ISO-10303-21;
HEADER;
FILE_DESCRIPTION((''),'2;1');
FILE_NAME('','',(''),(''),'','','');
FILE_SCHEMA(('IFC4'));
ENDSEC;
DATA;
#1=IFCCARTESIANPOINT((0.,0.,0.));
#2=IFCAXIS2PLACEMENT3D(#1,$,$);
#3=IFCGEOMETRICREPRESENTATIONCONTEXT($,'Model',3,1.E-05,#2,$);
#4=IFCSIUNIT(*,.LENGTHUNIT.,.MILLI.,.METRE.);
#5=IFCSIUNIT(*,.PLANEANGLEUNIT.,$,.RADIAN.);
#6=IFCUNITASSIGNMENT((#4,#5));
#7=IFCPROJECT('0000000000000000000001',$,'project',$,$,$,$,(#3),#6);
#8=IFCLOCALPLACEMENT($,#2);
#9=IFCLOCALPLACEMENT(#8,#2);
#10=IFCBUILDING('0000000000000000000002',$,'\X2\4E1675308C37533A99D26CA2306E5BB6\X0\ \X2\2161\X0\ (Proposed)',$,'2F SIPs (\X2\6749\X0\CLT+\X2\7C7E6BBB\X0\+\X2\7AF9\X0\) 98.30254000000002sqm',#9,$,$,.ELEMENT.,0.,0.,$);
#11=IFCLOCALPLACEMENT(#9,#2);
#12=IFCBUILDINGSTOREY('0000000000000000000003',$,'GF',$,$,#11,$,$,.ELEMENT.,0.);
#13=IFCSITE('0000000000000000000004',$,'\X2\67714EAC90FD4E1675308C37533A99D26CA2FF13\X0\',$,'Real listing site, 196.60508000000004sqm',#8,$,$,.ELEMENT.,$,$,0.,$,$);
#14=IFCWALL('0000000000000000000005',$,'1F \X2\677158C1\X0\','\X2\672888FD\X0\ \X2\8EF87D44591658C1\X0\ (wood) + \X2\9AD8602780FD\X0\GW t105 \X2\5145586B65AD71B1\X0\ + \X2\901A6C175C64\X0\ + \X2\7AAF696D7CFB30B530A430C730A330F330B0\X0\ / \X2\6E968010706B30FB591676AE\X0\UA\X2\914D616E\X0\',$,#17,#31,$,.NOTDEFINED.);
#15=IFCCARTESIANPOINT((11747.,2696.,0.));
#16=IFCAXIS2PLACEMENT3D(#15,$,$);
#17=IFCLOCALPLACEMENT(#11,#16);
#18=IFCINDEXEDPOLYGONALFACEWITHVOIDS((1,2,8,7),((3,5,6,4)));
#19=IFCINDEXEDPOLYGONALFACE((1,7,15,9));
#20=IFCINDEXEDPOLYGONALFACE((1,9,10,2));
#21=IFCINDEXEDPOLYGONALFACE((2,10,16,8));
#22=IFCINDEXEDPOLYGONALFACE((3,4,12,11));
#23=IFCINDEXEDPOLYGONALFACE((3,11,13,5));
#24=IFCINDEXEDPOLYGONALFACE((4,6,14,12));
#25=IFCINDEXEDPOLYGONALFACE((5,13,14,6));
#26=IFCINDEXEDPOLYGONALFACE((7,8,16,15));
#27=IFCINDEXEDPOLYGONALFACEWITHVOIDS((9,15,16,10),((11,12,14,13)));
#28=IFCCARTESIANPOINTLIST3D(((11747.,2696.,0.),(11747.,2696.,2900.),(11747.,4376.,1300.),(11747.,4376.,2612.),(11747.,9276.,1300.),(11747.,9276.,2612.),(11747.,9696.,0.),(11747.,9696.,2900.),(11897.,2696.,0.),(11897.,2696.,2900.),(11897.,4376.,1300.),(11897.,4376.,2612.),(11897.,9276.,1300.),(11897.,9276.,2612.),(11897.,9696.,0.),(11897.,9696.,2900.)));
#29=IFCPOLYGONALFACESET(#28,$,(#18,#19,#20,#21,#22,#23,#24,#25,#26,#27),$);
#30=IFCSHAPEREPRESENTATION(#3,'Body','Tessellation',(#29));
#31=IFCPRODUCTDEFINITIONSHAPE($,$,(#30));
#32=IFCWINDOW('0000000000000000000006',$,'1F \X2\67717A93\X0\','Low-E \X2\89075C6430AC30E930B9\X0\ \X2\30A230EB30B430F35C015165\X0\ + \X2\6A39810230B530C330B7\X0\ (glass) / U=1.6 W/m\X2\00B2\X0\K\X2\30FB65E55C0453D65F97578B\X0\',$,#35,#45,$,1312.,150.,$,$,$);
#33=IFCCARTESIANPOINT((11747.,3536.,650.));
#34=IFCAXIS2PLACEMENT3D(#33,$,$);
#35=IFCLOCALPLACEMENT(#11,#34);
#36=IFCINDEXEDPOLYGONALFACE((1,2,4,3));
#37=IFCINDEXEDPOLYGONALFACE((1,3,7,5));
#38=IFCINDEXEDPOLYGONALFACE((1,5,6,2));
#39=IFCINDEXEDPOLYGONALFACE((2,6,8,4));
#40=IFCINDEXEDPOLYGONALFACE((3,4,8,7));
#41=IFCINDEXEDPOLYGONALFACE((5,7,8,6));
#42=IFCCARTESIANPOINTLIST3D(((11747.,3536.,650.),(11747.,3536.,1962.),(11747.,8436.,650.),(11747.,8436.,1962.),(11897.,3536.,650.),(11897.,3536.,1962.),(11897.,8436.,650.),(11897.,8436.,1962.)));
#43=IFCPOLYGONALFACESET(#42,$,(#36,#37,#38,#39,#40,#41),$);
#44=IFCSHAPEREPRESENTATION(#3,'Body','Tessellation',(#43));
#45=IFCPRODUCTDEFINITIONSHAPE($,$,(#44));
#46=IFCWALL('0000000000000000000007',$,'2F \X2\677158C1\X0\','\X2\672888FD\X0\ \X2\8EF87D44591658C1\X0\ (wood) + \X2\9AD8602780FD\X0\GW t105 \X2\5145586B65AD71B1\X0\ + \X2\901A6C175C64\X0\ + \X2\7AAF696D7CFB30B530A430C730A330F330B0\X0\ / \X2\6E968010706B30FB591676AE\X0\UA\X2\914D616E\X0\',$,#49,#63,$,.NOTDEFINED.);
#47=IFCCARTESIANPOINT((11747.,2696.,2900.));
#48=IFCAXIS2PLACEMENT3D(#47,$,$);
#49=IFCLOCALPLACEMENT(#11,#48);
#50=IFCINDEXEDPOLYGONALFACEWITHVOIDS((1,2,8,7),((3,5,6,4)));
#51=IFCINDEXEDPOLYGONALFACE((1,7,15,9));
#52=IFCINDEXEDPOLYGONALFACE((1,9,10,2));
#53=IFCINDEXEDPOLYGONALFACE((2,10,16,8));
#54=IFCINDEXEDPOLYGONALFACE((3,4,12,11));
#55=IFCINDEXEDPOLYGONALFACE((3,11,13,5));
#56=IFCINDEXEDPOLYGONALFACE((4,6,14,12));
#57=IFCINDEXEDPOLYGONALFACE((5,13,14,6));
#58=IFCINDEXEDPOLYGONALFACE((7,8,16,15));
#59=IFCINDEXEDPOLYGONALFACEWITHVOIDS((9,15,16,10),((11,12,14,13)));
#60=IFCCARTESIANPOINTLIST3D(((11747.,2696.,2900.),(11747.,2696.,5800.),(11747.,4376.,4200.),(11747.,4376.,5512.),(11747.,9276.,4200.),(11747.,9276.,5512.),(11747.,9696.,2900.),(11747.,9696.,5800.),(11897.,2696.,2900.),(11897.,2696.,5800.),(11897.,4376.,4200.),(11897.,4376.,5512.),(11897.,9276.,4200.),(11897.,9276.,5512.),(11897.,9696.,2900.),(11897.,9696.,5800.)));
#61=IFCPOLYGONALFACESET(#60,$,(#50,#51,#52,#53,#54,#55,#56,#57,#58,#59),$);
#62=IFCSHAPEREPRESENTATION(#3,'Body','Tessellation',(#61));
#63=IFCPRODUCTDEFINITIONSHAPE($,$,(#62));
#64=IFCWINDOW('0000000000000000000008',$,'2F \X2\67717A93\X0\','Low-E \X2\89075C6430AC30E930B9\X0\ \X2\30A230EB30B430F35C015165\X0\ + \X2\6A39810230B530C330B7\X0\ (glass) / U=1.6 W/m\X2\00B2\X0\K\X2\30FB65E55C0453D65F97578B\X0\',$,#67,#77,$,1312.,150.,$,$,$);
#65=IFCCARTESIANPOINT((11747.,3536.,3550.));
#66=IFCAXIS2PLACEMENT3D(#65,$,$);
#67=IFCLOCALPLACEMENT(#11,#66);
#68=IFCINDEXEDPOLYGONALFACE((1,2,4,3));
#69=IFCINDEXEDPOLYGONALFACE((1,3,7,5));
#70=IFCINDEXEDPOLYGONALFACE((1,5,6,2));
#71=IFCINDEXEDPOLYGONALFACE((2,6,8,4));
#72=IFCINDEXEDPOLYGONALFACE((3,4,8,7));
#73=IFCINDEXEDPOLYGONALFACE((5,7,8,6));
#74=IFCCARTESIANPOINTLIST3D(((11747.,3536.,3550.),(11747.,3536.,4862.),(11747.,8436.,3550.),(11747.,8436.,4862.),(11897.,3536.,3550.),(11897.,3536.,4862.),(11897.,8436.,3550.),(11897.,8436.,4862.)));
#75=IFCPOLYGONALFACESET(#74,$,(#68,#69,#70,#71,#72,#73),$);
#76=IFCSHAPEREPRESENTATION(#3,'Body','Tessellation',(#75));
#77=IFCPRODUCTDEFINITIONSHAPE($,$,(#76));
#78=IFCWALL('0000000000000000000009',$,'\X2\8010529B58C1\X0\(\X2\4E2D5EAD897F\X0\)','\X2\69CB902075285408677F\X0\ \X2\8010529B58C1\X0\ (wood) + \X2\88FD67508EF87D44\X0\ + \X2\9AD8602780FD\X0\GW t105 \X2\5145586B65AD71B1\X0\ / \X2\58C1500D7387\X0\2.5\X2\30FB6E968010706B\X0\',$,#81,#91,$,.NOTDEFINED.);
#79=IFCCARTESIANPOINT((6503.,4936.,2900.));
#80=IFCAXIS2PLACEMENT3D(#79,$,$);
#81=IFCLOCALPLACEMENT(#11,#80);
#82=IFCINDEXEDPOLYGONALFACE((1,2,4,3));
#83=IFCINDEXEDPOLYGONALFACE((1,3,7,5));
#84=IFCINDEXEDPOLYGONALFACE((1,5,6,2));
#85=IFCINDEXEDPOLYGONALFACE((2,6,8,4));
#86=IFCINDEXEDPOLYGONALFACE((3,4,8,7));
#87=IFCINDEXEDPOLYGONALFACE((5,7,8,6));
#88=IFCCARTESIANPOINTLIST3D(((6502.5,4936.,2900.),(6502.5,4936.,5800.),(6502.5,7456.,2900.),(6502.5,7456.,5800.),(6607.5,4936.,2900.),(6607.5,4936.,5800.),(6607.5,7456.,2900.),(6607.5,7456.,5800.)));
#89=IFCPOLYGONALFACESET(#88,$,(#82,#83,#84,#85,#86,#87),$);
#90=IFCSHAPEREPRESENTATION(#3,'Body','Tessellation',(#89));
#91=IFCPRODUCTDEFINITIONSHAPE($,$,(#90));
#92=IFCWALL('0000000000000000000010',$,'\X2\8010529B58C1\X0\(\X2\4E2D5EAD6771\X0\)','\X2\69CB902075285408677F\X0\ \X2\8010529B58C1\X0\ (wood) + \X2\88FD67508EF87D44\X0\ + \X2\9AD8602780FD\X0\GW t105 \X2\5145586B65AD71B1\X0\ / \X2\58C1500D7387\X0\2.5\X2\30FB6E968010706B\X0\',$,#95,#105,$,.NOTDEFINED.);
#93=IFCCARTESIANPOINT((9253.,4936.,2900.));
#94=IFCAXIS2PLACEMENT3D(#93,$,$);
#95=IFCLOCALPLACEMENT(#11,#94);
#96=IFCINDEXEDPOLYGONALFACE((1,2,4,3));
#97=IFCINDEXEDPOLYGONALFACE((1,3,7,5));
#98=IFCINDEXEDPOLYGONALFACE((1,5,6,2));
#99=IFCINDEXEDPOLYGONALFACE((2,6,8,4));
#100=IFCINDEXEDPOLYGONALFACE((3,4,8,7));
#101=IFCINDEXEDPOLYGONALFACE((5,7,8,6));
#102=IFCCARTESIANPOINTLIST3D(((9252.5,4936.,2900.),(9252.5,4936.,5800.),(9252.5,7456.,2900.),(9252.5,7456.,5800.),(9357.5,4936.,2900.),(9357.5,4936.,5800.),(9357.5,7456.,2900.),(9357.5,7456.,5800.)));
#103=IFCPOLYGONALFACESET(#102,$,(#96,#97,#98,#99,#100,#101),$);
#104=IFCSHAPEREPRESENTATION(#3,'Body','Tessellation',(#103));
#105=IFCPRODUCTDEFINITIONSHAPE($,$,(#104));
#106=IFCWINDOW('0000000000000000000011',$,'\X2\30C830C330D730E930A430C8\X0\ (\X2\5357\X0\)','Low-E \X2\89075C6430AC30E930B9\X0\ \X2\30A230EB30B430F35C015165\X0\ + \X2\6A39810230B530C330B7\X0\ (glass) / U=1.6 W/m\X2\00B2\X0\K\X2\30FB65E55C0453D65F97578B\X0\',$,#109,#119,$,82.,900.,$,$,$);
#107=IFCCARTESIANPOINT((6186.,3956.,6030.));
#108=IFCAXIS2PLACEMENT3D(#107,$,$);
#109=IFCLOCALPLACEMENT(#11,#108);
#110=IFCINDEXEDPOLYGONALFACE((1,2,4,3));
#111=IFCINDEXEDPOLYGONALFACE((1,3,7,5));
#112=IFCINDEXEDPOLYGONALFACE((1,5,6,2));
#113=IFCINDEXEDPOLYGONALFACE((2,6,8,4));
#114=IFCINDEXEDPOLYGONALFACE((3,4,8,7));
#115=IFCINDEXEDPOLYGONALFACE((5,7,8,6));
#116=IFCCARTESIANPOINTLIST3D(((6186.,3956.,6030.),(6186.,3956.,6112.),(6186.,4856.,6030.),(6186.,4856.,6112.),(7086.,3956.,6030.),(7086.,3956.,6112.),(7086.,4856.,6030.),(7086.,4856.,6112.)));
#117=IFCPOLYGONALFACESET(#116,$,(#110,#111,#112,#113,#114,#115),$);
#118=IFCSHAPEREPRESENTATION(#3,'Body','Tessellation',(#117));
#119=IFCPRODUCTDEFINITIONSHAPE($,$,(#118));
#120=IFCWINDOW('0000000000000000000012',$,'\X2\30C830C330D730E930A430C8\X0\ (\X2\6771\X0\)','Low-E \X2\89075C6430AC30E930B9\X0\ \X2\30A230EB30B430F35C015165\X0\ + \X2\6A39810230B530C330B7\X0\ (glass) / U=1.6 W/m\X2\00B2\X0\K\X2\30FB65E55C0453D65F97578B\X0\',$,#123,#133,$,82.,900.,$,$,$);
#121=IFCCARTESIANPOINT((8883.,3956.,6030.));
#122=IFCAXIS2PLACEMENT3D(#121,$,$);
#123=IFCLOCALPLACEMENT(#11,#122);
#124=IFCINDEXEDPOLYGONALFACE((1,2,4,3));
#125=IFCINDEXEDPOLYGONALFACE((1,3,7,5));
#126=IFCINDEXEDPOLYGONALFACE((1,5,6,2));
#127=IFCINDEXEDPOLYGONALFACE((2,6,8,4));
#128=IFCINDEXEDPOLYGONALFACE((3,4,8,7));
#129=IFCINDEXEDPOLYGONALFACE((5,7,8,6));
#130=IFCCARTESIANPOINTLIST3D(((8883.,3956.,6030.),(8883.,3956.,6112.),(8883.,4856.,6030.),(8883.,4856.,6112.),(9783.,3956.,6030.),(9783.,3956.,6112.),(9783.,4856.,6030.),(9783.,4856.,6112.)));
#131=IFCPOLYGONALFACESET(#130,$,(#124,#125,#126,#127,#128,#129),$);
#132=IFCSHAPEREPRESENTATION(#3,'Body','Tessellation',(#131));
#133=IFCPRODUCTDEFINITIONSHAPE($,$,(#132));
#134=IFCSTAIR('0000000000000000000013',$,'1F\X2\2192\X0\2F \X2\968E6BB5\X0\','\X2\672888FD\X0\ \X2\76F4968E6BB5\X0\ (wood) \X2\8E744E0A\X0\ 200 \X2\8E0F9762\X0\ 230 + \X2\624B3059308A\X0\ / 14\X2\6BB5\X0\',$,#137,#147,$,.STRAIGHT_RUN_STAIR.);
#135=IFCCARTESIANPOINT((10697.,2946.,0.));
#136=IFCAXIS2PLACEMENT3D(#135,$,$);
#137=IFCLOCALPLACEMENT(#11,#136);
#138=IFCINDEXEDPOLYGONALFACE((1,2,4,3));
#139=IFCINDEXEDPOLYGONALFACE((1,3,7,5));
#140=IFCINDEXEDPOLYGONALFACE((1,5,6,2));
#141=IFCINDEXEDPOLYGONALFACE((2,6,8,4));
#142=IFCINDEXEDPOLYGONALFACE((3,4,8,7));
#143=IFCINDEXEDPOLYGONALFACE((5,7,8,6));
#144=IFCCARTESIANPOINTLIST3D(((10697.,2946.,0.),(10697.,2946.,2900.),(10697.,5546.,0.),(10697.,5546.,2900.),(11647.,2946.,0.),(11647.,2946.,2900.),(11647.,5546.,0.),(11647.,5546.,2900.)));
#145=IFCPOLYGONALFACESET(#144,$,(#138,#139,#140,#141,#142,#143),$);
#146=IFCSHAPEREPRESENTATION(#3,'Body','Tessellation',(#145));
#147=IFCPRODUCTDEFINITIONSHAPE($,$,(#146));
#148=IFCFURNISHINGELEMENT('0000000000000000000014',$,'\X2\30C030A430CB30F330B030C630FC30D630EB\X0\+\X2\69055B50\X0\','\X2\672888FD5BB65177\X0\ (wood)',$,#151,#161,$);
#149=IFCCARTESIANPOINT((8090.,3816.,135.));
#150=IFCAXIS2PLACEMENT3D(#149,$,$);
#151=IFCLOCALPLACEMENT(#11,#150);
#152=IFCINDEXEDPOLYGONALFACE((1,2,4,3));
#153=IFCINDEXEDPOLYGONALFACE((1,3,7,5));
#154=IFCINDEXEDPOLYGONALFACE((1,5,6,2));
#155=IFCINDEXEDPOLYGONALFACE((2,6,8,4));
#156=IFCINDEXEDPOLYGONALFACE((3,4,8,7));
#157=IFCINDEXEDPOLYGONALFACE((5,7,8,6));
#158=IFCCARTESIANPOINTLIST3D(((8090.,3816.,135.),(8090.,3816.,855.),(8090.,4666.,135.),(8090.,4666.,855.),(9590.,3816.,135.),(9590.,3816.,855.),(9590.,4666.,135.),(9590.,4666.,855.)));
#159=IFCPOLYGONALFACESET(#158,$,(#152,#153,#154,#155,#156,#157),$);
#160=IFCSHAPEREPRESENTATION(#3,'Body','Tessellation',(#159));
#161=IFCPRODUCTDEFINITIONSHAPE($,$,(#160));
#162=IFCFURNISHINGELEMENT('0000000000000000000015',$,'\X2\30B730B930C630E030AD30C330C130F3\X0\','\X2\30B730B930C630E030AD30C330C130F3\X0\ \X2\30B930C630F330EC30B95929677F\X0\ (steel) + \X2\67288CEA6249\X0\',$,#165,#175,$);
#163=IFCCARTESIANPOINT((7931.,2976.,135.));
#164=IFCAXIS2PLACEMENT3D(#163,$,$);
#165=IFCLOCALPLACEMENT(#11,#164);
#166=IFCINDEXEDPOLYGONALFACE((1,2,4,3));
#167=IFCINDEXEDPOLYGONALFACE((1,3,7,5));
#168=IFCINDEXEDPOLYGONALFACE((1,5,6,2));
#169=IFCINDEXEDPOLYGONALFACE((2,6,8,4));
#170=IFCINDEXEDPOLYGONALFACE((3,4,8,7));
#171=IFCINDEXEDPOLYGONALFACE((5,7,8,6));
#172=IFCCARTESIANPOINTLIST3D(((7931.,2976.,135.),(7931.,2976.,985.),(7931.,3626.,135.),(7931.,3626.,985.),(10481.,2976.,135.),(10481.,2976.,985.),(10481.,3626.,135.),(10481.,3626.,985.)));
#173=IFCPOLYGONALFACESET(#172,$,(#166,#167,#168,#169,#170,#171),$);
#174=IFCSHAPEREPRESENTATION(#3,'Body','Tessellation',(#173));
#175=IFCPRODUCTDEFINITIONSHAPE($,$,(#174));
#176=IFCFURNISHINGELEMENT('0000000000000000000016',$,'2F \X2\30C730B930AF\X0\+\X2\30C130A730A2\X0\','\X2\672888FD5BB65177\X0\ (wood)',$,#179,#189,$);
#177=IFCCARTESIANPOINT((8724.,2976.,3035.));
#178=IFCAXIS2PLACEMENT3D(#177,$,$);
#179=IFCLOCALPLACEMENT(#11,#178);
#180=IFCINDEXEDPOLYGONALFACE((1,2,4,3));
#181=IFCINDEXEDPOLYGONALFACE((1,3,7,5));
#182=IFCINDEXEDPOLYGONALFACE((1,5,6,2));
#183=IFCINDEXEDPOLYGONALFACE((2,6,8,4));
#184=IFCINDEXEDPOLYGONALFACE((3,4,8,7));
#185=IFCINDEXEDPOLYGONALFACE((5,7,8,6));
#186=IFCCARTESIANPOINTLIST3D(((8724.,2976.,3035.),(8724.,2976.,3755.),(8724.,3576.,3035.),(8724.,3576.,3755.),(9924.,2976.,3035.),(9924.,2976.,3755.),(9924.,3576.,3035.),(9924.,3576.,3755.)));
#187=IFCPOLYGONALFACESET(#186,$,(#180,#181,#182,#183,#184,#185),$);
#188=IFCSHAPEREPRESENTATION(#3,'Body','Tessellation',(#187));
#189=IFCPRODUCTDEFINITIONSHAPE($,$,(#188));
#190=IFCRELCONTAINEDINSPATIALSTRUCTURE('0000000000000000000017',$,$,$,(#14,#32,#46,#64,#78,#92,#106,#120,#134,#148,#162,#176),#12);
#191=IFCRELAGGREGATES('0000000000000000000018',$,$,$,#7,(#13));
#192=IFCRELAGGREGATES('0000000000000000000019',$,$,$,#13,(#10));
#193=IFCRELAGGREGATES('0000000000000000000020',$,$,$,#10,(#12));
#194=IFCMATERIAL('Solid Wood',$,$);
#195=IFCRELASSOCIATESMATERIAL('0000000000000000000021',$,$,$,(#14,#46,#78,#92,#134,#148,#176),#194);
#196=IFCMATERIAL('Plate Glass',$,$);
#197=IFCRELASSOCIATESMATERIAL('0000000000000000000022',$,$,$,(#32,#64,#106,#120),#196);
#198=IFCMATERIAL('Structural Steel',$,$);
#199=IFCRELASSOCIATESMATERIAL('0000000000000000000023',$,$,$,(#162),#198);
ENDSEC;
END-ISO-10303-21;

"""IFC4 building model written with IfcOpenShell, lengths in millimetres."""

from ifc_helpers import new_model, si_unit, frame, frame_2d, origin, place, context, project, spatial, rectangle, extrude, material, element, fill, save


model = new_model("IFC4")

# Units and contexts
model_context = context("Model", 3, precision=1e-05, world=origin())
ifc_project = project(units=[si_unit("LENGTHUNIT", "METRE", prefix="MILLI"), si_unit("PLANEANGLEUNIT", "RADIAN")], contexts=[model_context])

# Site, building, storey
site_placement = place(None, origin())
site = spatial("IfcSite", under=ifc_project, at=site_placement, Name="東京都世田谷区駒沢３", ObjectType="Real listing site, 196.60508000000004sqm", CompositionType="ELEMENT", RefElevation=0.0)
building_placement = place(site_placement, origin())
building = spatial("IfcBuilding", under=site, at=building_placement, Name="世田谷区駒沢の家 Ⅱ (Proposed)", ObjectType="2F SIPs (杉CLT+籾殻+竹) 98.30254000000002sqm", CompositionType="ELEMENT", ElevationOfRefHeight=0.0, ElevationOfTerrain=0.0)
storey_placement = place(building_placement, origin())
storey = spatial("IfcBuildingStorey", under=building, at=storey_placement, Name="GF", CompositionType="ELEMENT", Elevation=0.0)

# Shared definitions
ifc_material_1 = material(Name="Solid Wood")

# Wall, opening, window
wall_1_placement = place(storey_placement, frame((11747.0, 2696.0, 0.0)))
wall_1 = element("IfcWall", 1, at=wall_1_placement, inside=storey, material=ifc_material_1, Name="1F 東壁", Description="木製 軸組外壁 (wood) + 高性能GW t105 充填断熱 + 通気層 + 窯業系サイディング / 準耐火・外皮UA配慮", PredefinedType="NOTDEFINED", context=model_context, shape_type="SweptSolid", body=[
    extrude(rectangle(XDim=150.0, YDim=7000.0, at=frame_2d((75.0, 3500.0))), frame((11747.0, 2696.0, 0.0)), (0.0, 0.0, 1.0), 2900.0),
])
opening_1_placement = place(storey_placement, frame((11747.0, 3536.0, 650.0)))
opening_1 = element("IfcOpeningElement", 2, at=opening_1_placement, cuts=wall_1, PredefinedType="NOTDEFINED", context=model_context, shape_type="SweptSolid", body=[
    extrude(rectangle(XDim=150.0, YDim=4900.0, at=frame_2d((75.0, 2450.0))), frame((11747.0, 3536.0, 650.0)), (0.0, 0.0, 1.0), 1312.0),
])
ifc_material_2 = material(Name="Plate Glass")
window_1_placement = place(storey_placement, frame((11747.0, 3536.0, 650.0)))
window_1 = element("IfcWindow", 3, at=window_1_placement, inside=storey, material=ifc_material_2, Name="1F 東窓", Description="Low-E 複層ガラス アルゴン封入 + 樹脂サッシ (glass) / U=1.6 W/m²K・日射取得型", OverallHeight=1312.0, OverallWidth=150.0, context=model_context, shape_type="SweptSolid", body=[
    extrude(rectangle(XDim=150.0, YDim=4900.0, at=frame_2d((75.0, 2450.0))), frame((11747.0, 3536.0, 650.0)), (0.0, 0.0, 1.0), 1312.0),
])
fill(opening_1, window_1)

# Wall, opening, window
wall_2_placement = place(storey_placement, frame((11747.0, 2696.0, 2900.0)))
wall_2 = element("IfcWall", 4, at=wall_2_placement, inside=storey, material=ifc_material_1, Name="2F 東壁", Description="木製 軸組外壁 (wood) + 高性能GW t105 充填断熱 + 通気層 + 窯業系サイディング / 準耐火・外皮UA配慮", PredefinedType="NOTDEFINED", context=model_context, shape_type="SweptSolid", body=[
    extrude(rectangle(XDim=150.0, YDim=7000.0, at=frame_2d((75.0, 3500.0))), frame((11747.0, 2696.0, 2900.0)), (0.0, 0.0, 1.0), 2900.0),
])
opening_2_placement = place(storey_placement, frame((11747.0, 3536.0, 3550.0)))
opening_2 = element("IfcOpeningElement", 5, at=opening_2_placement, cuts=wall_2, PredefinedType="NOTDEFINED", context=model_context, shape_type="SweptSolid", body=[
    extrude(rectangle(XDim=150.0, YDim=4900.0, at=frame_2d((75.0, 2450.0))), frame((11747.0, 3536.0, 3550.0)), (0.0, 0.0, 1.0), 1312.0),
])
window_2_placement = place(storey_placement, frame((11747.0, 3536.0, 3550.0)))
window_2 = element("IfcWindow", 6, at=window_2_placement, inside=storey, material=ifc_material_2, Name="2F 東窓", Description="Low-E 複層ガラス アルゴン封入 + 樹脂サッシ (glass) / U=1.6 W/m²K・日射取得型", OverallHeight=1312.0, OverallWidth=150.0, context=model_context, shape_type="SweptSolid", body=[
    extrude(rectangle(XDim=150.0, YDim=4900.0, at=frame_2d((75.0, 2450.0))), frame((11747.0, 3536.0, 3550.0)), (0.0, 0.0, 1.0), 1312.0),
])
fill(opening_2, window_2)

# Walls
wall_3_placement = place(storey_placement, frame((6503.0, 4936.0, 2900.0)))
element("IfcWall", 7, at=wall_3_placement, inside=storey, material=ifc_material_1, Name="耐力壁(中庭西)", Description="構造用合板 耐力壁 (wood) + 製材軸組 + 高性能GW t105 充填断熱 / 壁倍率2.5・準耐火", PredefinedType="NOTDEFINED", context=model_context, shape_type="SweptSolid", body=[
    extrude(rectangle(XDim=105.0, YDim=2520.0, at=frame_2d((52.0, 1260.0))), frame((6503.0, 4936.0, 2900.0)), (0.0, 0.0, 1.0), 2900.0),
])
wall_4_placement = place(storey_placement, frame((9253.0, 4936.0, 2900.0)))
element("IfcWall", 8, at=wall_4_placement, inside=storey, material=ifc_material_1, Name="耐力壁(中庭東)", Description="構造用合板 耐力壁 (wood) + 製材軸組 + 高性能GW t105 充填断熱 / 壁倍率2.5・準耐火", PredefinedType="NOTDEFINED", context=model_context, shape_type="SweptSolid", body=[
    extrude(rectangle(XDim=105.0, YDim=2520.0, at=frame_2d((52.0, 1260.0))), frame((9253.0, 4936.0, 2900.0)), (0.0, 0.0, 1.0), 2900.0),
])

# Windows
window_3_placement = place(storey_placement, frame((6186.0, 3956.0, 6030.0)))
element("IfcWindow", 9, at=window_3_placement, inside=storey, material=ifc_material_2, Name="トップライト (南)", Description="Low-E 複層ガラス アルゴン封入 + 樹脂サッシ (glass) / U=1.6 W/m²K・日射取得型", OverallHeight=82.0, OverallWidth=900.0, context=model_context, shape_type="SweptSolid", body=[
    extrude(rectangle(XDim=900.0, YDim=900.0, at=frame_2d((450.0, 450.0))), frame((6186.0, 3956.0, 6030.0)), (0.0, 0.0, 1.0), 82.0),
])
window_4_placement = place(storey_placement, frame((8883.0, 3956.0, 6030.0)))
element("IfcWindow", 10, at=window_4_placement, inside=storey, material=ifc_material_2, Name="トップライト (東)", Description="Low-E 複層ガラス アルゴン封入 + 樹脂サッシ (glass) / U=1.6 W/m²K・日射取得型", OverallHeight=82.0, OverallWidth=900.0, context=model_context, shape_type="SweptSolid", body=[
    extrude(rectangle(XDim=900.0, YDim=900.0, at=frame_2d((450.0, 450.0))), frame((8883.0, 3956.0, 6030.0)), (0.0, 0.0, 1.0), 82.0),
])

# Stair
stair_placement = place(storey_placement, frame((10697.0, 2946.0, 0.0)))
element("IfcStair", 11, at=stair_placement, inside=storey, material=ifc_material_1, Name="1F→2F 階段", Description="木製 直階段 (wood) 蹴上 200 踏面 230 + 手すり / 14段", PredefinedType="STRAIGHT_RUN_STAIR", context=model_context, shape_type="SweptSolid", body=[
    extrude(rectangle(XDim=950.0, YDim=2600.0, at=frame_2d((475.0, 1300.0))), frame((10697.0, 2946.0, 0.0)), (0.0, 0.0, 1.0), 2900.0),
])

# Furnishing elements
furnishing_1_placement = place(storey_placement, frame((8090.0, 3816.0, 135.0)))
element("IfcFurnishingElement", 12, at=furnishing_1_placement, inside=storey, material=ifc_material_1, Name="ダイニングテーブル+椅子", Description="木製家具 (wood)", context=model_context, shape_type="SweptSolid", body=[
    extrude(rectangle(XDim=1500.0, YDim=850.0, at=frame_2d((750.0, 425.0))), frame((8090.0, 3816.0, 135.0)), (0.0, 0.0, 1.0), 720.0),
])
ifc_material_3 = material(Name="Structural Steel")
furnishing_2_placement = place(storey_placement, frame((7931.0, 2976.0, 135.0)))
element("IfcFurnishingElement", 13, at=furnishing_2_placement, inside=storey, material=ifc_material_3, Name="システムキッチン", Description="システムキッチン ステンレス天板 (steel) + 木質扉", context=model_context, shape_type="SweptSolid", body=[
    extrude(rectangle(XDim=2550.0, YDim=650.0, at=frame_2d((1275.0, 325.0))), frame((7931.0, 2976.0, 135.0)), (0.0, 0.0, 1.0), 850.0),
])
furnishing_3_placement = place(storey_placement, frame((8724.0, 2976.0, 3035.0)))
element("IfcFurnishingElement", 14, at=furnishing_3_placement, inside=storey, material=ifc_material_1, Name="2F デスク+チェア", Description="木製家具 (wood)", context=model_context, shape_type="SweptSolid", body=[
    extrude(rectangle(XDim=1200.0, YDim=600.0, at=frame_2d((600.0, 300.0))), frame((8724.0, 2976.0, 3035.0)), (0.0, 0.0, 1.0), 720.0),
])

save(model, "model.ifc")
